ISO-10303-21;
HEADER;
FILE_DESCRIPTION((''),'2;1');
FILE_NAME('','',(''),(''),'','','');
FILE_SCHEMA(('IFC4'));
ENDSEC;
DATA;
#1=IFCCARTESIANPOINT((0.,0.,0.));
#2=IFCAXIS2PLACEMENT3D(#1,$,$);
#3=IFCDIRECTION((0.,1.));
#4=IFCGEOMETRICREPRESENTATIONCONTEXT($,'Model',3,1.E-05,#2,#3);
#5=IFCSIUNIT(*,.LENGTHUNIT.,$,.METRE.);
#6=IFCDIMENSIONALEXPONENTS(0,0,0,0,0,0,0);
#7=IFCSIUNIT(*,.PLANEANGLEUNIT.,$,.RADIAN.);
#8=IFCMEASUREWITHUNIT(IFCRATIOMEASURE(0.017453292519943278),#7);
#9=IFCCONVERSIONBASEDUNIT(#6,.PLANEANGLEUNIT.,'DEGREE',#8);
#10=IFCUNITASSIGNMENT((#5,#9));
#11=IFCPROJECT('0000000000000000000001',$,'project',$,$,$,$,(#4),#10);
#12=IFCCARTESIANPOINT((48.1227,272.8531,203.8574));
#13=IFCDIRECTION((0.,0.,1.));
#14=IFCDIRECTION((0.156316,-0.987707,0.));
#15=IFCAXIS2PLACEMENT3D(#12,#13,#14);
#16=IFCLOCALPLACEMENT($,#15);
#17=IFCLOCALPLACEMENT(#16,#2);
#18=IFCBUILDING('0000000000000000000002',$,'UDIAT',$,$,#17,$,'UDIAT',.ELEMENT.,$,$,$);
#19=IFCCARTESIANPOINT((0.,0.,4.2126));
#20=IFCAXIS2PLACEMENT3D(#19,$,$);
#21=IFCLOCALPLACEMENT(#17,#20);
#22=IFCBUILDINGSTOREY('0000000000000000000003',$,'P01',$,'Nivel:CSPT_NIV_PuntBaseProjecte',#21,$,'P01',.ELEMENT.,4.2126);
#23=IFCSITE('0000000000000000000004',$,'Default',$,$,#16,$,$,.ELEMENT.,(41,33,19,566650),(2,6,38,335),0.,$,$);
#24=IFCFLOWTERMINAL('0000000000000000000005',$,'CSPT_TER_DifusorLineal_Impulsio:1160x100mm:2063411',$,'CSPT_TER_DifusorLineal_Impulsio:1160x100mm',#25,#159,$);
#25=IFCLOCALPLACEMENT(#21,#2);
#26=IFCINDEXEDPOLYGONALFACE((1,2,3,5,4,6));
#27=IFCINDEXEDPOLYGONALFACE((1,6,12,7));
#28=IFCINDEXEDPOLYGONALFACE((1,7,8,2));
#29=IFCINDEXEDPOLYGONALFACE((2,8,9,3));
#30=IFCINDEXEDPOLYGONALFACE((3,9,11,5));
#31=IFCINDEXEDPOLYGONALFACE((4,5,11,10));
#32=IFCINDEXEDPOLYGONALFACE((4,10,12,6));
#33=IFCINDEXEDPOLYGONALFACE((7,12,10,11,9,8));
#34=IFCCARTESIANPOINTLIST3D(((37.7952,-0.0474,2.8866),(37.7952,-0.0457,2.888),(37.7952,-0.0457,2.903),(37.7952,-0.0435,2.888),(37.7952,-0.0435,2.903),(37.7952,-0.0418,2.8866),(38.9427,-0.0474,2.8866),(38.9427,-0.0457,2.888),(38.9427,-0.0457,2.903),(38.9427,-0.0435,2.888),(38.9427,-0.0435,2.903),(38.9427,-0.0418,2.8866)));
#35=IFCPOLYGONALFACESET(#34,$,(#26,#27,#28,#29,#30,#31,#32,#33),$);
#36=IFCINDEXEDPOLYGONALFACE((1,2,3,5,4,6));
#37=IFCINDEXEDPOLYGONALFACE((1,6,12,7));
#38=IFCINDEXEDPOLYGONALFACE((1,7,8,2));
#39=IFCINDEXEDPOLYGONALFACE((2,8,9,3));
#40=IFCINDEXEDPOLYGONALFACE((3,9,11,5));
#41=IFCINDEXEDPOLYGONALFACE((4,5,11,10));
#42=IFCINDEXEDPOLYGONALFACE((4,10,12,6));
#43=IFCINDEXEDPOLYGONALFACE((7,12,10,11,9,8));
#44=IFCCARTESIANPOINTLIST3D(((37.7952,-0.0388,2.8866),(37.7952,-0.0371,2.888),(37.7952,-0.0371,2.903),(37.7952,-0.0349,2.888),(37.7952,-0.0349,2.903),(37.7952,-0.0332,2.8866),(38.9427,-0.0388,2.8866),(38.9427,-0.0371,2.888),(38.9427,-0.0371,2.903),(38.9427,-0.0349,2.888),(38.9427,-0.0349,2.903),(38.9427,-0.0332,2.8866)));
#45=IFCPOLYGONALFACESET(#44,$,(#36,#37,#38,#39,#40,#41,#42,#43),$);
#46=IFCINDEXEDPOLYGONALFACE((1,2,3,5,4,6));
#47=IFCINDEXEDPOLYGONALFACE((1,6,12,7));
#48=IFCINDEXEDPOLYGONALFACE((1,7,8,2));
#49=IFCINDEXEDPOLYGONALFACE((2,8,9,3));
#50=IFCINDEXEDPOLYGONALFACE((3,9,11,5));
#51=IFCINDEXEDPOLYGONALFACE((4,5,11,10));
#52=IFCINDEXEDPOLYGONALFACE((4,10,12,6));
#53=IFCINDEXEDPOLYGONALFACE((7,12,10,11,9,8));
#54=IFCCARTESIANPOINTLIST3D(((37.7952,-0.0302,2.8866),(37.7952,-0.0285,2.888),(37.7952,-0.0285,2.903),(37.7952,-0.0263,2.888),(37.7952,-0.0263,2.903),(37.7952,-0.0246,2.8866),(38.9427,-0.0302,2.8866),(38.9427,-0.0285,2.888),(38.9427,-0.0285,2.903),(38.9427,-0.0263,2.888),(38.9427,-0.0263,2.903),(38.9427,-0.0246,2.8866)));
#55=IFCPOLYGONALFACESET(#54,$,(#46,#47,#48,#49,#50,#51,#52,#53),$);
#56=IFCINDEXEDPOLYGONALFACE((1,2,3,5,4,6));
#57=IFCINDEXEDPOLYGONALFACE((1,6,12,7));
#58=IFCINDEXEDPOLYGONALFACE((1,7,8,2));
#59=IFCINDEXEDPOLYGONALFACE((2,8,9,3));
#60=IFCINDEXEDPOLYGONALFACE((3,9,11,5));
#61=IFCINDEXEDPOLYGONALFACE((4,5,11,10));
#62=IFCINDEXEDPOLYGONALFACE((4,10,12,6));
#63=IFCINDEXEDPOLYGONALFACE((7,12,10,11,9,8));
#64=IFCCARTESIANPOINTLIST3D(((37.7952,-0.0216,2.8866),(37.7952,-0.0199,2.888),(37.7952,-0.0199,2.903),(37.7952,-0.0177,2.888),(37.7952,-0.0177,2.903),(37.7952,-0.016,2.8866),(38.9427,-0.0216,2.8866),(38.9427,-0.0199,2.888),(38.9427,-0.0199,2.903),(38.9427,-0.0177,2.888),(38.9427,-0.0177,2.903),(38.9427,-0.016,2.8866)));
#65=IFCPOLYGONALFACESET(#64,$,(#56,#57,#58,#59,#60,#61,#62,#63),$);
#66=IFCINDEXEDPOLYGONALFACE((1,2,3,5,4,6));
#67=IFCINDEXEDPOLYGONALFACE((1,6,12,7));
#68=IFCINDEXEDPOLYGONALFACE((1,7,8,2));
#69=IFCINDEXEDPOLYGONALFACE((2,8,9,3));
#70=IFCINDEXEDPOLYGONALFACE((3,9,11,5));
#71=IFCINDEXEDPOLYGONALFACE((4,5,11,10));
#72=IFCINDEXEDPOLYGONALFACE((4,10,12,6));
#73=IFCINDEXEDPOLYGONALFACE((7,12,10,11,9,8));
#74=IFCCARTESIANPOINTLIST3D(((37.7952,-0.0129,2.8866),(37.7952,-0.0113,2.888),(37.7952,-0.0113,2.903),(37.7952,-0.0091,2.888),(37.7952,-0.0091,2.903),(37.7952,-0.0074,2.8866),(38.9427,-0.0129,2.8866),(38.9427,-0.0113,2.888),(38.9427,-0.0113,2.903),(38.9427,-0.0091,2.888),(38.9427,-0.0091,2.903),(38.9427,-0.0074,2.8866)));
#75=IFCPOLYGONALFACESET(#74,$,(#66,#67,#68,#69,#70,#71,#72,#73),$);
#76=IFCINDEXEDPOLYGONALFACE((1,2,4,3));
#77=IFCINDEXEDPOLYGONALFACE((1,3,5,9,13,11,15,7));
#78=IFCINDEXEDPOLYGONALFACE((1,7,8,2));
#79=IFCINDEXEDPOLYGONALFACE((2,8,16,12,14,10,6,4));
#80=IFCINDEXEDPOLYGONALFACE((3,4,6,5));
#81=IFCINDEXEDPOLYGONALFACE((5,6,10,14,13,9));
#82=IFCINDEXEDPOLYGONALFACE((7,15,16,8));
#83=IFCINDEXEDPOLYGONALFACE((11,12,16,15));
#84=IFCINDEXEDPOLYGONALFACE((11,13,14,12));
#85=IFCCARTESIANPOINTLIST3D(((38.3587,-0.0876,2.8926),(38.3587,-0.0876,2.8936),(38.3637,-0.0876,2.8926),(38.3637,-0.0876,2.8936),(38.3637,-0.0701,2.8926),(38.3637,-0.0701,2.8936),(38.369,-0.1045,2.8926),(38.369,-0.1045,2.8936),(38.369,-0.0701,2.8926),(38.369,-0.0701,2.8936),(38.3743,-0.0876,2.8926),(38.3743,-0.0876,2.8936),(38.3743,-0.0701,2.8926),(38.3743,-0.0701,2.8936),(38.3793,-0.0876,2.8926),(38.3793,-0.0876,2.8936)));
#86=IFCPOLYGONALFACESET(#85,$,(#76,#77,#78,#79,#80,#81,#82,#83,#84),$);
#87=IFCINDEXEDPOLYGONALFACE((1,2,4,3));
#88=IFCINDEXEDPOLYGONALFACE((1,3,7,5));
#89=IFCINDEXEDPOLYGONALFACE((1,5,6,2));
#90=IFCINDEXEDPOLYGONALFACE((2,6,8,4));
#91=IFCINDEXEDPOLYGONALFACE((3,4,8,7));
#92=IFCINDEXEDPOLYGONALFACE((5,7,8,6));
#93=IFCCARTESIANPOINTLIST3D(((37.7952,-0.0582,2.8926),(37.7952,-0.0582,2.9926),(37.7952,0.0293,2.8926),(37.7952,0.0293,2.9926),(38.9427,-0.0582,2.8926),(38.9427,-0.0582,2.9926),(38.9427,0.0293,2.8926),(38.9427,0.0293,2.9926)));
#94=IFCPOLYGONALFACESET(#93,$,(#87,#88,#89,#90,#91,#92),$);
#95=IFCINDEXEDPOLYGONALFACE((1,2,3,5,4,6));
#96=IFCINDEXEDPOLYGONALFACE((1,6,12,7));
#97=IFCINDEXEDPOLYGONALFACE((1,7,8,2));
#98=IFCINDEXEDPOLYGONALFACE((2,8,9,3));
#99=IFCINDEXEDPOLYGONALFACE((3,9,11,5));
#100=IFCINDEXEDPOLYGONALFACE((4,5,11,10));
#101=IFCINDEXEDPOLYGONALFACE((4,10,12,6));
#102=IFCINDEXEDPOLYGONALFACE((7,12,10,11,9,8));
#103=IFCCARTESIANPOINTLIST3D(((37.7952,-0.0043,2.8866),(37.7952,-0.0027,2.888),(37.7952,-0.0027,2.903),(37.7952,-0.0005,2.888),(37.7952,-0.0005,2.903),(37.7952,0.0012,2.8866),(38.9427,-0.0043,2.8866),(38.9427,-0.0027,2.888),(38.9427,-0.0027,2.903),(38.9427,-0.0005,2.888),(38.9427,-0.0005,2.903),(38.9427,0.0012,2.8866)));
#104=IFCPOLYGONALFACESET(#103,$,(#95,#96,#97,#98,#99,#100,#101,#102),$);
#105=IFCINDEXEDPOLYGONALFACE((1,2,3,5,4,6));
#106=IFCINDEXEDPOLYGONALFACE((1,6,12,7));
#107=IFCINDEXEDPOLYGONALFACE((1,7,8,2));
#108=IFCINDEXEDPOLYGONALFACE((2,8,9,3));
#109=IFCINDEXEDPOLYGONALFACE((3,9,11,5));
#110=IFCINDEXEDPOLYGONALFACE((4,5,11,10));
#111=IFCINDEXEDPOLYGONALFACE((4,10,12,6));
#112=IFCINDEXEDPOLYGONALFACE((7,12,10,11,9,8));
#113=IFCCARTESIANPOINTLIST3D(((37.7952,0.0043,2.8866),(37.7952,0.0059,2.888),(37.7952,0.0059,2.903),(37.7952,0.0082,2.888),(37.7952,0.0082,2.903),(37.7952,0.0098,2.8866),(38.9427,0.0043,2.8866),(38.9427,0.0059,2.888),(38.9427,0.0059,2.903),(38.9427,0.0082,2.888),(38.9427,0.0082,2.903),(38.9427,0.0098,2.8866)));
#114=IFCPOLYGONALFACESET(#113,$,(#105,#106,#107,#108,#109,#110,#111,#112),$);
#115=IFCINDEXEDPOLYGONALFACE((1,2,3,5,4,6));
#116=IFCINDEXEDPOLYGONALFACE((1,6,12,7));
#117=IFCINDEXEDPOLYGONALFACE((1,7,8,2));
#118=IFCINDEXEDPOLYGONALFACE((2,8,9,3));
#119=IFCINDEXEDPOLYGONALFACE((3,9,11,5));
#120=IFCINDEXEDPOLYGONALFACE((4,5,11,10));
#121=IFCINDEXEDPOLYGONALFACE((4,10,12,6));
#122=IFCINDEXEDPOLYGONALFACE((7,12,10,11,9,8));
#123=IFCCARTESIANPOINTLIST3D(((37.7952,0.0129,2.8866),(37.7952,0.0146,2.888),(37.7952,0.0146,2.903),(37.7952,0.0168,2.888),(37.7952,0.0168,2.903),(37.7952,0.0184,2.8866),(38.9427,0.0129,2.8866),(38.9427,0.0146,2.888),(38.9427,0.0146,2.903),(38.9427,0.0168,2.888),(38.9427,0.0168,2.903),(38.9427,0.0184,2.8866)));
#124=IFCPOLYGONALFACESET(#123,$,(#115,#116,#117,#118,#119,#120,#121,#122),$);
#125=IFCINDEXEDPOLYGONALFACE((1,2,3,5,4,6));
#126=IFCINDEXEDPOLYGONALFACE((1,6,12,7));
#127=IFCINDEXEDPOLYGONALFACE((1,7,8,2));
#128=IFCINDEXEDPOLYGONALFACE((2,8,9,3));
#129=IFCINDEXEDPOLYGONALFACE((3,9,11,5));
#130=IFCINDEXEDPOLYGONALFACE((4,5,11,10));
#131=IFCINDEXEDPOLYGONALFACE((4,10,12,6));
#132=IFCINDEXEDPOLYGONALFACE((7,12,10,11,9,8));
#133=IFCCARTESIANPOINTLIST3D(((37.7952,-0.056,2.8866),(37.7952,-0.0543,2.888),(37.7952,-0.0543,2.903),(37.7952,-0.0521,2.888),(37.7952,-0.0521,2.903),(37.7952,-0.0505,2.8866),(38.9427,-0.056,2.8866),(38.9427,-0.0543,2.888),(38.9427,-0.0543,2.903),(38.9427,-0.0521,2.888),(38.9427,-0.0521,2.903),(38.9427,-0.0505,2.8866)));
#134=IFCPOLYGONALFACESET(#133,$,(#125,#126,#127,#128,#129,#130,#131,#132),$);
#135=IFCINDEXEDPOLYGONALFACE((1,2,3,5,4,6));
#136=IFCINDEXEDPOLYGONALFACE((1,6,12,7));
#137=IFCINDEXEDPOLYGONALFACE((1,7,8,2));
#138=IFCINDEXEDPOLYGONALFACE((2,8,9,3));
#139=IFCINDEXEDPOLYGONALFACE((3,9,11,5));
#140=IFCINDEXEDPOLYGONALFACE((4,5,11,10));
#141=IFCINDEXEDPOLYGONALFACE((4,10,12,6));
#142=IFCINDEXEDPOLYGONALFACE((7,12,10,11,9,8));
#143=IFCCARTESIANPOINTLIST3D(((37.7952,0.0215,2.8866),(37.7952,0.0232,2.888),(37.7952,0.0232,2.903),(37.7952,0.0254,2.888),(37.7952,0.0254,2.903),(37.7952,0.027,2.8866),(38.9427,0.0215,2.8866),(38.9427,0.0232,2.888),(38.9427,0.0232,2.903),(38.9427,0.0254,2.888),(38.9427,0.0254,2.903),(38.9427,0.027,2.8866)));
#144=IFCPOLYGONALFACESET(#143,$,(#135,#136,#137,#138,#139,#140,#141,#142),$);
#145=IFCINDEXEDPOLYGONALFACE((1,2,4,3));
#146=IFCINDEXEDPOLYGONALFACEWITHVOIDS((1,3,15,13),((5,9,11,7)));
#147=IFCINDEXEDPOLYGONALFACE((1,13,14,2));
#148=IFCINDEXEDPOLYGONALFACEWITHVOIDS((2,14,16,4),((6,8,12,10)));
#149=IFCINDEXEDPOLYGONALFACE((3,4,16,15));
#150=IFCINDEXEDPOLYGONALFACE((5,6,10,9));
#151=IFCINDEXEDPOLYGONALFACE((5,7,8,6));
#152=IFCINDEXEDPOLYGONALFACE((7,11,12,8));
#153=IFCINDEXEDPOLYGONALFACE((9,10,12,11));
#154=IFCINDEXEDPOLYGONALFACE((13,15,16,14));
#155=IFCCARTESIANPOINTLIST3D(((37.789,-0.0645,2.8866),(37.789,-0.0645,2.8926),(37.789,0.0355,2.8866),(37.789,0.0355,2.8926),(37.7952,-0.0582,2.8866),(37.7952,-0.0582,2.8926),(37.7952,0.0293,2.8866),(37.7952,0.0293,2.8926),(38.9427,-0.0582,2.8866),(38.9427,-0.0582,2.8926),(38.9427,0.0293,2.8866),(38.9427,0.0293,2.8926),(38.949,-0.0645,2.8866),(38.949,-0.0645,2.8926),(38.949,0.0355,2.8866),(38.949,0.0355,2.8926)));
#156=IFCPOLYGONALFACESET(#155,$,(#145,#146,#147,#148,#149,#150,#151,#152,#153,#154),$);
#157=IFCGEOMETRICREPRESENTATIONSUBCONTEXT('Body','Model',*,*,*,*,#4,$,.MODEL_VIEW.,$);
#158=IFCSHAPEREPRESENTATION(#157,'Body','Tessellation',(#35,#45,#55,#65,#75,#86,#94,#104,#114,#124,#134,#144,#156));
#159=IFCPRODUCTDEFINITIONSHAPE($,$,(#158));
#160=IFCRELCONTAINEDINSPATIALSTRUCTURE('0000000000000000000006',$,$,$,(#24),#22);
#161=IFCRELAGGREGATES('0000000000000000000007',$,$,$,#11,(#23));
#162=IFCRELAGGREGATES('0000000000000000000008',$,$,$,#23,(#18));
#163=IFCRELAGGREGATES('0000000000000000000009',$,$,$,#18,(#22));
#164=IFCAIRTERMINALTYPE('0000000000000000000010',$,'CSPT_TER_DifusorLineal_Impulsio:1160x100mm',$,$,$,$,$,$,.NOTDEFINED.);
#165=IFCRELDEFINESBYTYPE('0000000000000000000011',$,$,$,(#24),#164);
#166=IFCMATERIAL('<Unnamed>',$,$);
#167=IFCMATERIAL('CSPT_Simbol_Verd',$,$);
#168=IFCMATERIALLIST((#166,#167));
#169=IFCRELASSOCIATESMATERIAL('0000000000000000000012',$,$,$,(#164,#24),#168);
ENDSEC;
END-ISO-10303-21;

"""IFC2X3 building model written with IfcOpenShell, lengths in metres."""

from ifc_helpers import new_model, entity, si_unit, converted_unit, direction, frame, origin, origin_2d_with_axis, place, context, subcontext, project, spatial, polyline, rectangle, outline, extrude, source, transform, mapped, material, material_list, type_object, type_shapes, element, save


model = new_model("IFC2X3")

# Units and contexts
model_context = context("Model", 3, precision=1e-05, world=origin(), true_north=direction((0.0, 1.0)))
body_context = subcontext(model_context, "Body", "Model", "MODEL_VIEW")
ifc_project = project(units=[si_unit("LENGTHUNIT", "METRE"), converted_unit("PLANEANGLEUNIT", "DEGREE", entity("IfcRatioMeasure", 0.017453292519943278), si_unit("PLANEANGLEUNIT", "RADIAN"), dimensions=[0, 0, 0, 0, 0, 0, 0])], contexts=[model_context])

# Site, building, storey
site_placement = place(None, frame((48.1227, 272.8531, 203.8574), z_axis=(0.0, 0.0, 1.0), x_axis=(0.156316, -0.987707, 0.0)))
site = spatial("IfcSite", under=ifc_project, at=site_placement, Name="Default", CompositionType="ELEMENT", RefLatitude=(41, 33, 19, 566650), RefLongitude=(2, 6, 38, 335), RefElevation=0.0)
building_placement = place(site_placement, origin())
building = spatial("IfcBuilding", under=site, at=building_placement, Name="UDIAT", LongName="UDIAT", CompositionType="ELEMENT")
storey_placement = place(building_placement, frame((0.0, 0.0, 4.2126)))
storey = spatial("IfcBuildingStorey", under=building, at=storey_placement, Name="P01", ObjectType="Nivel:CSPT_NIV_PuntBaseProjecte", LongName="P01", CompositionType="ELEMENT", Elevation=4.2126)

# Shared definitions
ifc_material_1 = material(Name="<Unnamed>")

# Flow terminal
ifc_material_2 = material(Name="CSPT_Simbol_Verd")
ifc_material_list = material_list([ifc_material_1, ifc_material_2])
air_terminal_type = type_object("IfcAirTerminalType", Name="CSPT_TER_DifusorLineal_Impulsio:1160x100mm", PredefinedType="NOTDEFINED", material=ifc_material_list)
shared_shape_1 = source(origin(), body_context, "Body", "SweptSolid", [
    extrude(outline(polyline([(0.0037, 0.0028), (0.0059, 0.0028), (0.0016, 0.0063), (0.002, 0.0042), (-0.0074, -0.0074), (-0.0057, -0.0088), (0.0037, 0.0028)])), frame((-0.5737, 0.0301, -0.0001), z_axis=(1.0, 0.0, 0.0), x_axis=(0.0, -0.776119, -0.630587)), (0.0, 0.0, 1.0), 1.1475),
    extrude(outline(polyline([(0.0037, 0.0028), (0.0059, 0.0028), (0.0016, 0.0063), (0.002, 0.0042), (-0.0074, -0.0074), (-0.0057, -0.0088), (0.0037, 0.0028)])), frame((-0.5737, 0.0215, -0.0001), z_axis=(1.0, 0.0, 0.0), x_axis=(0.0, -0.776119, -0.630587)), (0.0, 0.0, 1.0), 1.1475),
    extrude(outline(polyline([(0.0037, 0.0028), (0.0059, 0.0028), (0.0016, 0.0063), (0.002, 0.0042), (-0.0074, -0.0074), (-0.0057, -0.0088), (0.0037, 0.0028)])), frame((-0.5737, 0.0129, -0.0001), z_axis=(1.0, 0.0, 0.0), x_axis=(0.0, -0.776119, -0.630587)), (0.0, 0.0, 1.0), 1.1475),
    extrude(outline(polyline([(0.0037, 0.0028), (0.0059, 0.0028), (0.0016, 0.0063), (0.002, 0.0042), (-0.0074, -0.0074), (-0.0057, -0.0088), (0.0037, 0.0028)])), frame((-0.5737, 0.0043, -0.0001), z_axis=(1.0, 0.0, 0.0), x_axis=(0.0, -0.776119, -0.630587)), (0.0, 0.0, 1.0), 1.1475),
    extrude(outline(polyline([(0.0037, 0.0028), (0.0059, 0.0028), (0.0016, 0.0063), (0.002, 0.0042), (-0.0074, -0.0074), (-0.0057, -0.0088), (0.0037, 0.0028)])), frame((-0.5737, -0.0043, -0.0001), z_axis=(1.0, 0.0, 0.0), x_axis=(0.0, -0.776119, -0.630587)), (0.0, 0.0, 1.0), 1.1475),
    extrude(outline(polyline([(0.0, -0.013), (0.0053, -0.013), (0.0053, 0.0045), (0.0103, 0.0045), (0.0, 0.0213), (-0.0103, 0.0045), (-0.0053, 0.0045), (-0.0053, -0.013), (0.0, -0.013)])), frame((0.0, 0.0687, 0.0)), (0.0, 0.0, 1.0), 0.001),
    extrude(rectangle(XDim=1.1475, YDim=0.0875, at=origin_2d_with_axis()), frame((0.0, 0.0, 0.0), z_axis=(0.0, 0.0, 1.0), x_axis=(-1.0, 0.0, 0.0)), (0.0, 0.0, 1.0), 0.1),
    extrude(outline(polyline([(0.0037, 0.0028), (0.0059, 0.0028), (0.0016, 0.0063), (0.002, 0.0042), (-0.0074, -0.0074), (-0.0057, -0.0088), (0.0037, 0.0028)])), frame((-0.5737, -0.0129, -0.0001), z_axis=(1.0, 0.0, 0.0), x_axis=(0.0, -0.776119, -0.630587)), (0.0, 0.0, 1.0), 1.1475),
    extrude(outline(polyline([(0.0037, 0.0028), (0.0059, 0.0028), (0.0016, 0.0063), (0.002, 0.0042), (-0.0074, -0.0074), (-0.0057, -0.0088), (0.0037, 0.0028)])), frame((-0.5737, -0.0215, -0.0001), z_axis=(1.0, 0.0, 0.0), x_axis=(0.0, -0.776119, -0.630587)), (0.0, 0.0, 1.0), 1.1475),
    extrude(outline(polyline([(0.0037, 0.0028), (0.0059, 0.0028), (0.0016, 0.0063), (0.002, 0.0042), (-0.0074, -0.0074), (-0.0057, -0.0088), (0.0037, 0.0028)])), frame((-0.5737, -0.0301, -0.0001), z_axis=(1.0, 0.0, 0.0), x_axis=(0.0, -0.776119, -0.630587)), (0.0, 0.0, 1.0), 1.1475),
    extrude(outline(polyline([(0.0037, 0.0028), (0.0059, 0.0028), (0.0016, 0.0063), (0.002, 0.0042), (-0.0074, -0.0074), (-0.0057, -0.0088), (0.0037, 0.0028)])), frame((-0.5737, 0.0388, -0.0001), z_axis=(1.0, 0.0, 0.0), x_axis=(0.0, -0.776119, -0.630587)), (0.0, 0.0, 1.0), 1.1475),
    extrude(outline(polyline([(0.0037, 0.0028), (0.0059, 0.0028), (0.0016, 0.0063), (0.002, 0.0042), (-0.0074, -0.0074), (-0.0057, -0.0088), (0.0037, 0.0028)])), frame((-0.5737, -0.0387, -0.0001), z_axis=(1.0, 0.0, 0.0), x_axis=(0.0, -0.776119, -0.630587)), (0.0, 0.0, 1.0), 1.1475),
    extrude(outline(polyline([(-0.58, -0.05), (0.58, -0.05), (0.58, 0.05), (-0.58, 0.05), (-0.58, -0.05)]), holes=[polyline([(-0.5738, -0.0438), (-0.5738, 0.0437), (0.5737, 0.0437), (0.5737, -0.0438), (-0.5738, -0.0438)])]), frame((0.0, 0.0, -0.006), z_axis=(0.0, 0.0, 1.0), x_axis=(-1.0, 0.0, 0.0)), (0.0, 0.0, 1.0), 0.006),
])
type_shapes(air_terminal_type, [shared_shape_1])
for number, where, z_axis, x_axis, name in (
    (1, (38.369, -0.0145, 2.8926), (0.0, 0.0, 1.0), (-1.0, 0.0, 0.0), "CSPT_TER_DifusorLineal_Impulsio:1160x100mm:2063411"),
):
    element("IfcFlowTerminal", number, at=place(storey_placement, frame(where, z_axis=z_axis, x_axis=x_axis)), inside=storey, type_object=air_terminal_type, material=ifc_material_list, Name=name, ObjectType="CSPT_TER_DifusorLineal_Impulsio:1160x100mm", context=body_context, shape_type="MappedRepresentation", body=[
        mapped(shared_shape_1, transform((0.0, 0.0, 0.0), scale=1.0)),
    ])

save(model, "model.ifc")
